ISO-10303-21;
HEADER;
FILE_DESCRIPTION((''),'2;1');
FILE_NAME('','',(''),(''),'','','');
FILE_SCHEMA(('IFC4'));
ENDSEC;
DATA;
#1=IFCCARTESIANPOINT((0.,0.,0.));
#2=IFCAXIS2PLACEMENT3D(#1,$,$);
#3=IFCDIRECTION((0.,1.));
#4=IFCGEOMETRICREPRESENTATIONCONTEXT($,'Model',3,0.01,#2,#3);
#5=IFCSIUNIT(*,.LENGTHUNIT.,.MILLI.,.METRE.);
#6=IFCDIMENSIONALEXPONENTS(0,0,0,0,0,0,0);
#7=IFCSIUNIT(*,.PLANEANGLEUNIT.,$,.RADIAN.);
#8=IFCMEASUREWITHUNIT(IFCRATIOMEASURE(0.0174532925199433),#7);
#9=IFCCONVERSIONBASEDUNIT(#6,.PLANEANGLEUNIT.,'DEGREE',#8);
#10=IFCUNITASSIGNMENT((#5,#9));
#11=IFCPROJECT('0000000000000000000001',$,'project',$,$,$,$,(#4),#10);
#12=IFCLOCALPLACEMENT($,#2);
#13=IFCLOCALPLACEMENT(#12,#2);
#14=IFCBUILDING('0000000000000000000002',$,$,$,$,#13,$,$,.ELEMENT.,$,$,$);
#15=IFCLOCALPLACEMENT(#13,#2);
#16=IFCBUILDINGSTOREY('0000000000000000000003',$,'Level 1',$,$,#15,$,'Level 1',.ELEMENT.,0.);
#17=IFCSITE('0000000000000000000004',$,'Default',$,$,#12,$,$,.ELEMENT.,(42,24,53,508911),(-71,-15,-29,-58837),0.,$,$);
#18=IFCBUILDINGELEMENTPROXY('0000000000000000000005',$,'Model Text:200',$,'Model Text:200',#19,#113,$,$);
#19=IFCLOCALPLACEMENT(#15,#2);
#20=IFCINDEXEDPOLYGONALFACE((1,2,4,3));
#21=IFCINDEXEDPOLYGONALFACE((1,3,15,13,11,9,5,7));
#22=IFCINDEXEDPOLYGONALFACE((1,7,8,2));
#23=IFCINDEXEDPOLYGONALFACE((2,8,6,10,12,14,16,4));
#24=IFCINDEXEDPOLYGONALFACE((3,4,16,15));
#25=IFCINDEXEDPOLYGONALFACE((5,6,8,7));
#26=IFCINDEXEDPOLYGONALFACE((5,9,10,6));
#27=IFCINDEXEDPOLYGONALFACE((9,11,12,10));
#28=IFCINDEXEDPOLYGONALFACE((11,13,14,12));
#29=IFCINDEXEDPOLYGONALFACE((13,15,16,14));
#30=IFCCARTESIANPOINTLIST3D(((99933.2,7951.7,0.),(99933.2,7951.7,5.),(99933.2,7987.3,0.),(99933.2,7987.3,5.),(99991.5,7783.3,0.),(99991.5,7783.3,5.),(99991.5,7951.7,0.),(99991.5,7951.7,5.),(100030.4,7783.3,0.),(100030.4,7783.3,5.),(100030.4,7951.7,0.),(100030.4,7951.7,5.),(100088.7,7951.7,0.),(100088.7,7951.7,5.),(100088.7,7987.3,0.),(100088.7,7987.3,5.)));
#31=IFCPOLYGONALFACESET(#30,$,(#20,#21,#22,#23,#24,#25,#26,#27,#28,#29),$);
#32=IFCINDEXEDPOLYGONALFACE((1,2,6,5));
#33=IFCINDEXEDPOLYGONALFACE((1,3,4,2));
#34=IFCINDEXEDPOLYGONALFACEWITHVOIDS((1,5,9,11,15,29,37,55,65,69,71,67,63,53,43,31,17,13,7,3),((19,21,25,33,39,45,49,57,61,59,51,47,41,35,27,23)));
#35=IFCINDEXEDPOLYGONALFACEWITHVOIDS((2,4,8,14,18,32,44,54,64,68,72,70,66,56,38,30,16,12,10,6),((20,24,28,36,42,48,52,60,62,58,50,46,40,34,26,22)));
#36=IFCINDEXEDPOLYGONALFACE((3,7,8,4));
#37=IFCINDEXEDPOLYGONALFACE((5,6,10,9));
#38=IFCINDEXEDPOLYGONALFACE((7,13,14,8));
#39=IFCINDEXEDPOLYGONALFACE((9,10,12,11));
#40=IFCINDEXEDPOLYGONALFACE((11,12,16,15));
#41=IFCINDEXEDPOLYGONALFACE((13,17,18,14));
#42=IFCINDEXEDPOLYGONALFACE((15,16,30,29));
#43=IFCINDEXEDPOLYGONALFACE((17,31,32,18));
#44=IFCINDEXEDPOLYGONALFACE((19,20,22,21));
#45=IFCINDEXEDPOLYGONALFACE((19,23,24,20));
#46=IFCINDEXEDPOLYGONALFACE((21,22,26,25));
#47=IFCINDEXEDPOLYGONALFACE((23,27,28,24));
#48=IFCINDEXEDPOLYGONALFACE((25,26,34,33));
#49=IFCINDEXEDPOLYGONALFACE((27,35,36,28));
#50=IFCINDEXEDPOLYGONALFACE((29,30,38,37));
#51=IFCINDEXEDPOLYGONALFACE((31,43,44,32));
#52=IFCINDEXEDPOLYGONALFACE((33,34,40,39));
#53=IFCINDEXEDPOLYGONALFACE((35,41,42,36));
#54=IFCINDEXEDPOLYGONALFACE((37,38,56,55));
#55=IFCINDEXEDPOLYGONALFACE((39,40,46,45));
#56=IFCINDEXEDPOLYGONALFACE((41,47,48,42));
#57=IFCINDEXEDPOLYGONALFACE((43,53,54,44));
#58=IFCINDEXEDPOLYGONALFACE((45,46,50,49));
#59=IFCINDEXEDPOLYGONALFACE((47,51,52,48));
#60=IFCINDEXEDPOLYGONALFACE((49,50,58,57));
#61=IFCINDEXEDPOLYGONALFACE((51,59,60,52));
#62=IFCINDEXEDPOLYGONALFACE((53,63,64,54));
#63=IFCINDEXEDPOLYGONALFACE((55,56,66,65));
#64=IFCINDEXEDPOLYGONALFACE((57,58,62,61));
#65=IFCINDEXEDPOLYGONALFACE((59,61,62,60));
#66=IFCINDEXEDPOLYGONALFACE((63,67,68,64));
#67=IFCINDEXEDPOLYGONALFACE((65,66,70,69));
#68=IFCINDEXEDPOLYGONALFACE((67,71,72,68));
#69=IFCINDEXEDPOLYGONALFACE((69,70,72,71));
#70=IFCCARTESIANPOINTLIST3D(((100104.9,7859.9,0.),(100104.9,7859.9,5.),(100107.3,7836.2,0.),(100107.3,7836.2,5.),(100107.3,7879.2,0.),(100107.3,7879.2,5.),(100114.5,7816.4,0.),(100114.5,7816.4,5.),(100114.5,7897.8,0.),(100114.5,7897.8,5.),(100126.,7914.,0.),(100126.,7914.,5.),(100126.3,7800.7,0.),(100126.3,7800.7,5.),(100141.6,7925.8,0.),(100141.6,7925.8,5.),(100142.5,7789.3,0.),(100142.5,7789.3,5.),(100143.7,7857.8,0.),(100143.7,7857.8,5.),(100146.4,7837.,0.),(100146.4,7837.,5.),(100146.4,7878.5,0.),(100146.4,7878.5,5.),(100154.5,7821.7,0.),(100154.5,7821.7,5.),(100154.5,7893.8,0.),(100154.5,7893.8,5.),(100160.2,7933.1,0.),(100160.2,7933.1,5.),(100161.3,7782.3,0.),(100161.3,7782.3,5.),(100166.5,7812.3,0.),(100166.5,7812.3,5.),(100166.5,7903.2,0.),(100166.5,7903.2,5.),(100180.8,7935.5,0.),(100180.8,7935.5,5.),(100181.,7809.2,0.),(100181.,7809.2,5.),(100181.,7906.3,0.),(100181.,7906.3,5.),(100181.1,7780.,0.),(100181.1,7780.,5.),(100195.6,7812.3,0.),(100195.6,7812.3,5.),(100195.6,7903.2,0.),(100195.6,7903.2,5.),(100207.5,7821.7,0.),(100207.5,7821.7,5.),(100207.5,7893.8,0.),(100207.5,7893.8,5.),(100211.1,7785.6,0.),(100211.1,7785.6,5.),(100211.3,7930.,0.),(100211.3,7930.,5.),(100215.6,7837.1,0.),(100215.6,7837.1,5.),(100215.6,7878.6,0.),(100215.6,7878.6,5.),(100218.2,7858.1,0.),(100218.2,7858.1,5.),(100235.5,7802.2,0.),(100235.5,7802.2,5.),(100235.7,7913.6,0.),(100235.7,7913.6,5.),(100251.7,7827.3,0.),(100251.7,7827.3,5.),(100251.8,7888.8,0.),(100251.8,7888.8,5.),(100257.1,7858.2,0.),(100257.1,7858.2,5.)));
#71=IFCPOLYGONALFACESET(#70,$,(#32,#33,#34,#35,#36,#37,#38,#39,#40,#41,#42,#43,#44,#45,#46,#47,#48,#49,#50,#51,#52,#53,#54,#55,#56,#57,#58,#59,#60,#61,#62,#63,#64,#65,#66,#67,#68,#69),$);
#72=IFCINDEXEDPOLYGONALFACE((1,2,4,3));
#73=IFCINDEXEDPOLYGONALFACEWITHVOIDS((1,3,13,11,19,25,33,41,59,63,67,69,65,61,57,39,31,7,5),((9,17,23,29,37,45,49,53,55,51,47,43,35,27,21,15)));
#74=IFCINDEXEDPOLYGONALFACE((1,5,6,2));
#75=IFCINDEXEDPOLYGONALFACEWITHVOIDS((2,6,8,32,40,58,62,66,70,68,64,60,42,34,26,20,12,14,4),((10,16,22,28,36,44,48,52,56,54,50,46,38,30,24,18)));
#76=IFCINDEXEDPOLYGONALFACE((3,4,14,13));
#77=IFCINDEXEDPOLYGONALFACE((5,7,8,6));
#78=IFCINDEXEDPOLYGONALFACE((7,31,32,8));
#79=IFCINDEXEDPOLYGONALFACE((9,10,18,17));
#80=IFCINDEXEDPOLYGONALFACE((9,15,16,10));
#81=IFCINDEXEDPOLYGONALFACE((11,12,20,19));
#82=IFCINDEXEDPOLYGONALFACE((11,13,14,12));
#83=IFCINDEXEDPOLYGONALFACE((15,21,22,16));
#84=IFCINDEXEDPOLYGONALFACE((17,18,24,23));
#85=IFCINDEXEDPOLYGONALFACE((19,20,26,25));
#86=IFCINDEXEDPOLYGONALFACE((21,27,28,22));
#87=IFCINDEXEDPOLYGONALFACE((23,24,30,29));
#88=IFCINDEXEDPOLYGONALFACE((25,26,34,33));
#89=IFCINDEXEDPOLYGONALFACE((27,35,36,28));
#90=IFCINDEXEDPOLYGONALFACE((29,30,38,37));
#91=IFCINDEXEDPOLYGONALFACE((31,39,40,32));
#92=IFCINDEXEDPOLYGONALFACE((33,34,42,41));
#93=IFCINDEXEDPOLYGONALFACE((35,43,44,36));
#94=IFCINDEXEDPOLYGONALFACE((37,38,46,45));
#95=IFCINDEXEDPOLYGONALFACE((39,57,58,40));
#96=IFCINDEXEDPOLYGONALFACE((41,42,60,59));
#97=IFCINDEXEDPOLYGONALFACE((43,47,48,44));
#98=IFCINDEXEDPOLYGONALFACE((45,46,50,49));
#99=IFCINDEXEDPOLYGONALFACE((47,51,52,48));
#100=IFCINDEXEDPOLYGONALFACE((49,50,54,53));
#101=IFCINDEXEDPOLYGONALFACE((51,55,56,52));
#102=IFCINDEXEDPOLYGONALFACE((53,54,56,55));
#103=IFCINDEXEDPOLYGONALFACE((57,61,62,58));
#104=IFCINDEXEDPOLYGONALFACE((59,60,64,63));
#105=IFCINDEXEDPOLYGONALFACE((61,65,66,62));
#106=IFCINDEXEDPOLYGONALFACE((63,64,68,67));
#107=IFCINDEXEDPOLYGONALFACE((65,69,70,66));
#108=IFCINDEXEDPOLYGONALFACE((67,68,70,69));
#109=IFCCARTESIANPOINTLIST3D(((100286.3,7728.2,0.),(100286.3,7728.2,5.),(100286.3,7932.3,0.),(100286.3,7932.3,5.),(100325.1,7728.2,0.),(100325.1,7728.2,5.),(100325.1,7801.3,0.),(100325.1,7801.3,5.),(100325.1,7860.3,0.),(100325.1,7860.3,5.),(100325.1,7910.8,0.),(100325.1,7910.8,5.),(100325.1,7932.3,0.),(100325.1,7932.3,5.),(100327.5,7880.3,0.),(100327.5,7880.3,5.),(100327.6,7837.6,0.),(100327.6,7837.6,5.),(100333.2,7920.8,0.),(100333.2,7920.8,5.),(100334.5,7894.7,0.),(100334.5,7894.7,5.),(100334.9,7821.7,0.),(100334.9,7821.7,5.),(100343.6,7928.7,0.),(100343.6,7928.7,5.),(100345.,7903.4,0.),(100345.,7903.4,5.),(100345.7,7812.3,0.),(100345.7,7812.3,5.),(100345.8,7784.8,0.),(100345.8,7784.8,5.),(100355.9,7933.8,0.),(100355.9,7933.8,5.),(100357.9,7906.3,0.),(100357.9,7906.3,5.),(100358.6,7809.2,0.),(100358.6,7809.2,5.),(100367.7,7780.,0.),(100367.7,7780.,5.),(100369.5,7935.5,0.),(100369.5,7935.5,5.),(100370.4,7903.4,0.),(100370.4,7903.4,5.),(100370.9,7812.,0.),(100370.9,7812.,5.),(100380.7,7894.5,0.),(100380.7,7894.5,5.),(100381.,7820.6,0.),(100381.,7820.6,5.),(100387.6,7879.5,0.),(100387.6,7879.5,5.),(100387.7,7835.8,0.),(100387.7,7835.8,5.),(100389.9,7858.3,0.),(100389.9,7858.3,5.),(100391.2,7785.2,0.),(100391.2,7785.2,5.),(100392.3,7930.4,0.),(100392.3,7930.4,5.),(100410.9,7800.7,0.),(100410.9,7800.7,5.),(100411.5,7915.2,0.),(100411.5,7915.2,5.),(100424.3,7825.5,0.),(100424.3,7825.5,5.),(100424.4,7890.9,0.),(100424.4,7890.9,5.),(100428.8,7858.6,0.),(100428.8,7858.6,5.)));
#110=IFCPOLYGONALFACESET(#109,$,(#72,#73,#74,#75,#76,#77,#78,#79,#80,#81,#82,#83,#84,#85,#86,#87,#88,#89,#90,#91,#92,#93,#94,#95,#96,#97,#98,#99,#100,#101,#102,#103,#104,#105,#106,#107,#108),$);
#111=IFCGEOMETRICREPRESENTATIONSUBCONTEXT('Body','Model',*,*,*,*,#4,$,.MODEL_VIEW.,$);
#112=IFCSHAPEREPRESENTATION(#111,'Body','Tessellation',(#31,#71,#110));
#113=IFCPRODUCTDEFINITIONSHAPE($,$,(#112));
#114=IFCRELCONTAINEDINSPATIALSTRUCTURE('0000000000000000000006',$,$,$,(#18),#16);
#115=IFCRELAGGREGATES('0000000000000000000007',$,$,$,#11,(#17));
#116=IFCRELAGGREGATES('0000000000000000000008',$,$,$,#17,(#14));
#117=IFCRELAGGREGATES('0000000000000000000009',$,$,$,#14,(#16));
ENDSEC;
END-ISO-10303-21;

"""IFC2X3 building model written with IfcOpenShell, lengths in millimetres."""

from ifc_helpers import new_model, entity, si_unit, converted_unit, direction, frame, origin, place, context, subcontext, project, spatial, polyline, outline, extrude, element, save


model = new_model("IFC2X3")

# Units and contexts
model_context = context("Model", 3, precision=0.01, world=origin(), true_north=direction((0.0, 1.0)))
body_context = subcontext(model_context, "Body", "Model", "MODEL_VIEW")
ifc_project = project(units=[si_unit("LENGTHUNIT", "METRE", prefix="MILLI"), converted_unit("PLANEANGLEUNIT", "DEGREE", entity("IfcRatioMeasure", 0.0174532925199433), si_unit("PLANEANGLEUNIT", "RADIAN"), dimensions=[0, 0, 0, 0, 0, 0, 0])], contexts=[model_context])

# Site, building, storey
site_placement = place(None, origin())
site = spatial("IfcSite", under=ifc_project, at=site_placement, Name="Default", CompositionType="ELEMENT", RefLatitude=(42, 24, 53, 508911), RefLongitude=(-71, -15, -29, -58837), RefElevation=0.0)
building_placement = place(site_placement, origin())
building = spatial("IfcBuilding", under=site, at=building_placement, CompositionType="ELEMENT")
storey_placement = place(building_placement, origin())
storey = spatial("IfcBuildingStorey", under=building, at=storey_placement, Name="Level 1", LongName="Level 1", CompositionType="ELEMENT", Elevation=0.0)

# Building element proxy
proxy_1_placement = place(storey_placement, origin())
element("IfcBuildingElementProxy", 1, at=proxy_1_placement, inside=storey, Name="Model Text:200", ObjectType="Model Text:200", context=body_context, shape_type="SweptSolid", body=[
    extrude(outline(polyline([(-19.4, -135.2), (19.4, -135.2), (19.4, 33.2), (77.7, 33.2), (77.7, 68.8), (-77.7, 68.8), (-77.7, 33.2), (-19.4, 33.2), (-19.4, -135.2)])), frame((100010.9, 7918.5, 0.0)), (0.0, 0.0, 1.0), 5.0),
    extrude(outline(polyline([(-8.8, -65.7), (15.1, -65.7), (35.5, -60.5), (52.3, -50.4), (65.3, -35.4), (74.1, -17.3), (78.4, 2.1), (75.9, 32.5), (61.8, 58.5), (38.4, 77.1), (8.3, 85.6), (-22.7, 83.3), (-49.0, 69.9), (-67.8, 47.3), (-76.3, 17.5), (-76.0, -3.3), (-70.7, -22.5), (-60.5, -39.2), (-45.5, -52.3), (-27.7, -61.4), (-8.8, -65.7)]), holes=[polyline([(-2.7, -27.2), (-23.1, -22.5), (-37.5, -12.9), (-45.7, 0.0), (-47.3, 14.8), (-42.7, 28.9), (-32.2, 39.9), (-16.3, 46.3), (4.5, 46.9), (25.1, 42.1), (39.6, 32.6), (47.7, 19.7), (49.4, 5.0), (44.8, -9.2), (34.2, -20.2), (18.2, -26.7), (-2.7, -27.2)])]), frame((100171.1, 7857.8, 0.0), z_axis=(0.0, 0.0, 1.0), x_axis=(0.100608, -0.994926, 0.0)), (0.0, 0.0, 1.0), 5.0),
    extrude(outline(polyline([(-73.1, -75.4), (130.9, -75.4), (130.9, -36.6), (57.8, -36.6), (74.3, -15.9), (79.1, 6.0), (73.9, 29.5), (58.4, 49.2), (33.6, 62.6), (0.5, 67.1), (-31.8, 62.8), (-56.1, 49.8), (-71.3, 30.7), (-76.4, 7.8), (-74.7, -5.8), (-69.6, -18.1), (-61.7, -28.5), (-51.7, -36.6), (-73.1, -36.6), (-73.1, -75.4)]), holes=[polyline([(-1.2, -36.6), (-21.2, -34.2), (-35.6, -27.2), (-44.3, -16.7), (-47.2, -3.8), (-44.3, 8.7), (-35.4, 19.0), (-20.4, 25.9), (0.8, 28.2), (23.3, 26.0), (38.5, 19.3), (47.1, 9.2), (49.9, -3.1), (46.8, -16.0), (37.4, -26.8), (21.5, -34.1), (-1.2, -36.6)])]), frame((100361.7, 7859.1, 0.0), z_axis=(0.0, 0.0, 1.0), x_axis=(0.0, -1.0, 0.0)), (0.0, 0.0, 1.0), 5.0),
])

save(model, "model.ifc")
